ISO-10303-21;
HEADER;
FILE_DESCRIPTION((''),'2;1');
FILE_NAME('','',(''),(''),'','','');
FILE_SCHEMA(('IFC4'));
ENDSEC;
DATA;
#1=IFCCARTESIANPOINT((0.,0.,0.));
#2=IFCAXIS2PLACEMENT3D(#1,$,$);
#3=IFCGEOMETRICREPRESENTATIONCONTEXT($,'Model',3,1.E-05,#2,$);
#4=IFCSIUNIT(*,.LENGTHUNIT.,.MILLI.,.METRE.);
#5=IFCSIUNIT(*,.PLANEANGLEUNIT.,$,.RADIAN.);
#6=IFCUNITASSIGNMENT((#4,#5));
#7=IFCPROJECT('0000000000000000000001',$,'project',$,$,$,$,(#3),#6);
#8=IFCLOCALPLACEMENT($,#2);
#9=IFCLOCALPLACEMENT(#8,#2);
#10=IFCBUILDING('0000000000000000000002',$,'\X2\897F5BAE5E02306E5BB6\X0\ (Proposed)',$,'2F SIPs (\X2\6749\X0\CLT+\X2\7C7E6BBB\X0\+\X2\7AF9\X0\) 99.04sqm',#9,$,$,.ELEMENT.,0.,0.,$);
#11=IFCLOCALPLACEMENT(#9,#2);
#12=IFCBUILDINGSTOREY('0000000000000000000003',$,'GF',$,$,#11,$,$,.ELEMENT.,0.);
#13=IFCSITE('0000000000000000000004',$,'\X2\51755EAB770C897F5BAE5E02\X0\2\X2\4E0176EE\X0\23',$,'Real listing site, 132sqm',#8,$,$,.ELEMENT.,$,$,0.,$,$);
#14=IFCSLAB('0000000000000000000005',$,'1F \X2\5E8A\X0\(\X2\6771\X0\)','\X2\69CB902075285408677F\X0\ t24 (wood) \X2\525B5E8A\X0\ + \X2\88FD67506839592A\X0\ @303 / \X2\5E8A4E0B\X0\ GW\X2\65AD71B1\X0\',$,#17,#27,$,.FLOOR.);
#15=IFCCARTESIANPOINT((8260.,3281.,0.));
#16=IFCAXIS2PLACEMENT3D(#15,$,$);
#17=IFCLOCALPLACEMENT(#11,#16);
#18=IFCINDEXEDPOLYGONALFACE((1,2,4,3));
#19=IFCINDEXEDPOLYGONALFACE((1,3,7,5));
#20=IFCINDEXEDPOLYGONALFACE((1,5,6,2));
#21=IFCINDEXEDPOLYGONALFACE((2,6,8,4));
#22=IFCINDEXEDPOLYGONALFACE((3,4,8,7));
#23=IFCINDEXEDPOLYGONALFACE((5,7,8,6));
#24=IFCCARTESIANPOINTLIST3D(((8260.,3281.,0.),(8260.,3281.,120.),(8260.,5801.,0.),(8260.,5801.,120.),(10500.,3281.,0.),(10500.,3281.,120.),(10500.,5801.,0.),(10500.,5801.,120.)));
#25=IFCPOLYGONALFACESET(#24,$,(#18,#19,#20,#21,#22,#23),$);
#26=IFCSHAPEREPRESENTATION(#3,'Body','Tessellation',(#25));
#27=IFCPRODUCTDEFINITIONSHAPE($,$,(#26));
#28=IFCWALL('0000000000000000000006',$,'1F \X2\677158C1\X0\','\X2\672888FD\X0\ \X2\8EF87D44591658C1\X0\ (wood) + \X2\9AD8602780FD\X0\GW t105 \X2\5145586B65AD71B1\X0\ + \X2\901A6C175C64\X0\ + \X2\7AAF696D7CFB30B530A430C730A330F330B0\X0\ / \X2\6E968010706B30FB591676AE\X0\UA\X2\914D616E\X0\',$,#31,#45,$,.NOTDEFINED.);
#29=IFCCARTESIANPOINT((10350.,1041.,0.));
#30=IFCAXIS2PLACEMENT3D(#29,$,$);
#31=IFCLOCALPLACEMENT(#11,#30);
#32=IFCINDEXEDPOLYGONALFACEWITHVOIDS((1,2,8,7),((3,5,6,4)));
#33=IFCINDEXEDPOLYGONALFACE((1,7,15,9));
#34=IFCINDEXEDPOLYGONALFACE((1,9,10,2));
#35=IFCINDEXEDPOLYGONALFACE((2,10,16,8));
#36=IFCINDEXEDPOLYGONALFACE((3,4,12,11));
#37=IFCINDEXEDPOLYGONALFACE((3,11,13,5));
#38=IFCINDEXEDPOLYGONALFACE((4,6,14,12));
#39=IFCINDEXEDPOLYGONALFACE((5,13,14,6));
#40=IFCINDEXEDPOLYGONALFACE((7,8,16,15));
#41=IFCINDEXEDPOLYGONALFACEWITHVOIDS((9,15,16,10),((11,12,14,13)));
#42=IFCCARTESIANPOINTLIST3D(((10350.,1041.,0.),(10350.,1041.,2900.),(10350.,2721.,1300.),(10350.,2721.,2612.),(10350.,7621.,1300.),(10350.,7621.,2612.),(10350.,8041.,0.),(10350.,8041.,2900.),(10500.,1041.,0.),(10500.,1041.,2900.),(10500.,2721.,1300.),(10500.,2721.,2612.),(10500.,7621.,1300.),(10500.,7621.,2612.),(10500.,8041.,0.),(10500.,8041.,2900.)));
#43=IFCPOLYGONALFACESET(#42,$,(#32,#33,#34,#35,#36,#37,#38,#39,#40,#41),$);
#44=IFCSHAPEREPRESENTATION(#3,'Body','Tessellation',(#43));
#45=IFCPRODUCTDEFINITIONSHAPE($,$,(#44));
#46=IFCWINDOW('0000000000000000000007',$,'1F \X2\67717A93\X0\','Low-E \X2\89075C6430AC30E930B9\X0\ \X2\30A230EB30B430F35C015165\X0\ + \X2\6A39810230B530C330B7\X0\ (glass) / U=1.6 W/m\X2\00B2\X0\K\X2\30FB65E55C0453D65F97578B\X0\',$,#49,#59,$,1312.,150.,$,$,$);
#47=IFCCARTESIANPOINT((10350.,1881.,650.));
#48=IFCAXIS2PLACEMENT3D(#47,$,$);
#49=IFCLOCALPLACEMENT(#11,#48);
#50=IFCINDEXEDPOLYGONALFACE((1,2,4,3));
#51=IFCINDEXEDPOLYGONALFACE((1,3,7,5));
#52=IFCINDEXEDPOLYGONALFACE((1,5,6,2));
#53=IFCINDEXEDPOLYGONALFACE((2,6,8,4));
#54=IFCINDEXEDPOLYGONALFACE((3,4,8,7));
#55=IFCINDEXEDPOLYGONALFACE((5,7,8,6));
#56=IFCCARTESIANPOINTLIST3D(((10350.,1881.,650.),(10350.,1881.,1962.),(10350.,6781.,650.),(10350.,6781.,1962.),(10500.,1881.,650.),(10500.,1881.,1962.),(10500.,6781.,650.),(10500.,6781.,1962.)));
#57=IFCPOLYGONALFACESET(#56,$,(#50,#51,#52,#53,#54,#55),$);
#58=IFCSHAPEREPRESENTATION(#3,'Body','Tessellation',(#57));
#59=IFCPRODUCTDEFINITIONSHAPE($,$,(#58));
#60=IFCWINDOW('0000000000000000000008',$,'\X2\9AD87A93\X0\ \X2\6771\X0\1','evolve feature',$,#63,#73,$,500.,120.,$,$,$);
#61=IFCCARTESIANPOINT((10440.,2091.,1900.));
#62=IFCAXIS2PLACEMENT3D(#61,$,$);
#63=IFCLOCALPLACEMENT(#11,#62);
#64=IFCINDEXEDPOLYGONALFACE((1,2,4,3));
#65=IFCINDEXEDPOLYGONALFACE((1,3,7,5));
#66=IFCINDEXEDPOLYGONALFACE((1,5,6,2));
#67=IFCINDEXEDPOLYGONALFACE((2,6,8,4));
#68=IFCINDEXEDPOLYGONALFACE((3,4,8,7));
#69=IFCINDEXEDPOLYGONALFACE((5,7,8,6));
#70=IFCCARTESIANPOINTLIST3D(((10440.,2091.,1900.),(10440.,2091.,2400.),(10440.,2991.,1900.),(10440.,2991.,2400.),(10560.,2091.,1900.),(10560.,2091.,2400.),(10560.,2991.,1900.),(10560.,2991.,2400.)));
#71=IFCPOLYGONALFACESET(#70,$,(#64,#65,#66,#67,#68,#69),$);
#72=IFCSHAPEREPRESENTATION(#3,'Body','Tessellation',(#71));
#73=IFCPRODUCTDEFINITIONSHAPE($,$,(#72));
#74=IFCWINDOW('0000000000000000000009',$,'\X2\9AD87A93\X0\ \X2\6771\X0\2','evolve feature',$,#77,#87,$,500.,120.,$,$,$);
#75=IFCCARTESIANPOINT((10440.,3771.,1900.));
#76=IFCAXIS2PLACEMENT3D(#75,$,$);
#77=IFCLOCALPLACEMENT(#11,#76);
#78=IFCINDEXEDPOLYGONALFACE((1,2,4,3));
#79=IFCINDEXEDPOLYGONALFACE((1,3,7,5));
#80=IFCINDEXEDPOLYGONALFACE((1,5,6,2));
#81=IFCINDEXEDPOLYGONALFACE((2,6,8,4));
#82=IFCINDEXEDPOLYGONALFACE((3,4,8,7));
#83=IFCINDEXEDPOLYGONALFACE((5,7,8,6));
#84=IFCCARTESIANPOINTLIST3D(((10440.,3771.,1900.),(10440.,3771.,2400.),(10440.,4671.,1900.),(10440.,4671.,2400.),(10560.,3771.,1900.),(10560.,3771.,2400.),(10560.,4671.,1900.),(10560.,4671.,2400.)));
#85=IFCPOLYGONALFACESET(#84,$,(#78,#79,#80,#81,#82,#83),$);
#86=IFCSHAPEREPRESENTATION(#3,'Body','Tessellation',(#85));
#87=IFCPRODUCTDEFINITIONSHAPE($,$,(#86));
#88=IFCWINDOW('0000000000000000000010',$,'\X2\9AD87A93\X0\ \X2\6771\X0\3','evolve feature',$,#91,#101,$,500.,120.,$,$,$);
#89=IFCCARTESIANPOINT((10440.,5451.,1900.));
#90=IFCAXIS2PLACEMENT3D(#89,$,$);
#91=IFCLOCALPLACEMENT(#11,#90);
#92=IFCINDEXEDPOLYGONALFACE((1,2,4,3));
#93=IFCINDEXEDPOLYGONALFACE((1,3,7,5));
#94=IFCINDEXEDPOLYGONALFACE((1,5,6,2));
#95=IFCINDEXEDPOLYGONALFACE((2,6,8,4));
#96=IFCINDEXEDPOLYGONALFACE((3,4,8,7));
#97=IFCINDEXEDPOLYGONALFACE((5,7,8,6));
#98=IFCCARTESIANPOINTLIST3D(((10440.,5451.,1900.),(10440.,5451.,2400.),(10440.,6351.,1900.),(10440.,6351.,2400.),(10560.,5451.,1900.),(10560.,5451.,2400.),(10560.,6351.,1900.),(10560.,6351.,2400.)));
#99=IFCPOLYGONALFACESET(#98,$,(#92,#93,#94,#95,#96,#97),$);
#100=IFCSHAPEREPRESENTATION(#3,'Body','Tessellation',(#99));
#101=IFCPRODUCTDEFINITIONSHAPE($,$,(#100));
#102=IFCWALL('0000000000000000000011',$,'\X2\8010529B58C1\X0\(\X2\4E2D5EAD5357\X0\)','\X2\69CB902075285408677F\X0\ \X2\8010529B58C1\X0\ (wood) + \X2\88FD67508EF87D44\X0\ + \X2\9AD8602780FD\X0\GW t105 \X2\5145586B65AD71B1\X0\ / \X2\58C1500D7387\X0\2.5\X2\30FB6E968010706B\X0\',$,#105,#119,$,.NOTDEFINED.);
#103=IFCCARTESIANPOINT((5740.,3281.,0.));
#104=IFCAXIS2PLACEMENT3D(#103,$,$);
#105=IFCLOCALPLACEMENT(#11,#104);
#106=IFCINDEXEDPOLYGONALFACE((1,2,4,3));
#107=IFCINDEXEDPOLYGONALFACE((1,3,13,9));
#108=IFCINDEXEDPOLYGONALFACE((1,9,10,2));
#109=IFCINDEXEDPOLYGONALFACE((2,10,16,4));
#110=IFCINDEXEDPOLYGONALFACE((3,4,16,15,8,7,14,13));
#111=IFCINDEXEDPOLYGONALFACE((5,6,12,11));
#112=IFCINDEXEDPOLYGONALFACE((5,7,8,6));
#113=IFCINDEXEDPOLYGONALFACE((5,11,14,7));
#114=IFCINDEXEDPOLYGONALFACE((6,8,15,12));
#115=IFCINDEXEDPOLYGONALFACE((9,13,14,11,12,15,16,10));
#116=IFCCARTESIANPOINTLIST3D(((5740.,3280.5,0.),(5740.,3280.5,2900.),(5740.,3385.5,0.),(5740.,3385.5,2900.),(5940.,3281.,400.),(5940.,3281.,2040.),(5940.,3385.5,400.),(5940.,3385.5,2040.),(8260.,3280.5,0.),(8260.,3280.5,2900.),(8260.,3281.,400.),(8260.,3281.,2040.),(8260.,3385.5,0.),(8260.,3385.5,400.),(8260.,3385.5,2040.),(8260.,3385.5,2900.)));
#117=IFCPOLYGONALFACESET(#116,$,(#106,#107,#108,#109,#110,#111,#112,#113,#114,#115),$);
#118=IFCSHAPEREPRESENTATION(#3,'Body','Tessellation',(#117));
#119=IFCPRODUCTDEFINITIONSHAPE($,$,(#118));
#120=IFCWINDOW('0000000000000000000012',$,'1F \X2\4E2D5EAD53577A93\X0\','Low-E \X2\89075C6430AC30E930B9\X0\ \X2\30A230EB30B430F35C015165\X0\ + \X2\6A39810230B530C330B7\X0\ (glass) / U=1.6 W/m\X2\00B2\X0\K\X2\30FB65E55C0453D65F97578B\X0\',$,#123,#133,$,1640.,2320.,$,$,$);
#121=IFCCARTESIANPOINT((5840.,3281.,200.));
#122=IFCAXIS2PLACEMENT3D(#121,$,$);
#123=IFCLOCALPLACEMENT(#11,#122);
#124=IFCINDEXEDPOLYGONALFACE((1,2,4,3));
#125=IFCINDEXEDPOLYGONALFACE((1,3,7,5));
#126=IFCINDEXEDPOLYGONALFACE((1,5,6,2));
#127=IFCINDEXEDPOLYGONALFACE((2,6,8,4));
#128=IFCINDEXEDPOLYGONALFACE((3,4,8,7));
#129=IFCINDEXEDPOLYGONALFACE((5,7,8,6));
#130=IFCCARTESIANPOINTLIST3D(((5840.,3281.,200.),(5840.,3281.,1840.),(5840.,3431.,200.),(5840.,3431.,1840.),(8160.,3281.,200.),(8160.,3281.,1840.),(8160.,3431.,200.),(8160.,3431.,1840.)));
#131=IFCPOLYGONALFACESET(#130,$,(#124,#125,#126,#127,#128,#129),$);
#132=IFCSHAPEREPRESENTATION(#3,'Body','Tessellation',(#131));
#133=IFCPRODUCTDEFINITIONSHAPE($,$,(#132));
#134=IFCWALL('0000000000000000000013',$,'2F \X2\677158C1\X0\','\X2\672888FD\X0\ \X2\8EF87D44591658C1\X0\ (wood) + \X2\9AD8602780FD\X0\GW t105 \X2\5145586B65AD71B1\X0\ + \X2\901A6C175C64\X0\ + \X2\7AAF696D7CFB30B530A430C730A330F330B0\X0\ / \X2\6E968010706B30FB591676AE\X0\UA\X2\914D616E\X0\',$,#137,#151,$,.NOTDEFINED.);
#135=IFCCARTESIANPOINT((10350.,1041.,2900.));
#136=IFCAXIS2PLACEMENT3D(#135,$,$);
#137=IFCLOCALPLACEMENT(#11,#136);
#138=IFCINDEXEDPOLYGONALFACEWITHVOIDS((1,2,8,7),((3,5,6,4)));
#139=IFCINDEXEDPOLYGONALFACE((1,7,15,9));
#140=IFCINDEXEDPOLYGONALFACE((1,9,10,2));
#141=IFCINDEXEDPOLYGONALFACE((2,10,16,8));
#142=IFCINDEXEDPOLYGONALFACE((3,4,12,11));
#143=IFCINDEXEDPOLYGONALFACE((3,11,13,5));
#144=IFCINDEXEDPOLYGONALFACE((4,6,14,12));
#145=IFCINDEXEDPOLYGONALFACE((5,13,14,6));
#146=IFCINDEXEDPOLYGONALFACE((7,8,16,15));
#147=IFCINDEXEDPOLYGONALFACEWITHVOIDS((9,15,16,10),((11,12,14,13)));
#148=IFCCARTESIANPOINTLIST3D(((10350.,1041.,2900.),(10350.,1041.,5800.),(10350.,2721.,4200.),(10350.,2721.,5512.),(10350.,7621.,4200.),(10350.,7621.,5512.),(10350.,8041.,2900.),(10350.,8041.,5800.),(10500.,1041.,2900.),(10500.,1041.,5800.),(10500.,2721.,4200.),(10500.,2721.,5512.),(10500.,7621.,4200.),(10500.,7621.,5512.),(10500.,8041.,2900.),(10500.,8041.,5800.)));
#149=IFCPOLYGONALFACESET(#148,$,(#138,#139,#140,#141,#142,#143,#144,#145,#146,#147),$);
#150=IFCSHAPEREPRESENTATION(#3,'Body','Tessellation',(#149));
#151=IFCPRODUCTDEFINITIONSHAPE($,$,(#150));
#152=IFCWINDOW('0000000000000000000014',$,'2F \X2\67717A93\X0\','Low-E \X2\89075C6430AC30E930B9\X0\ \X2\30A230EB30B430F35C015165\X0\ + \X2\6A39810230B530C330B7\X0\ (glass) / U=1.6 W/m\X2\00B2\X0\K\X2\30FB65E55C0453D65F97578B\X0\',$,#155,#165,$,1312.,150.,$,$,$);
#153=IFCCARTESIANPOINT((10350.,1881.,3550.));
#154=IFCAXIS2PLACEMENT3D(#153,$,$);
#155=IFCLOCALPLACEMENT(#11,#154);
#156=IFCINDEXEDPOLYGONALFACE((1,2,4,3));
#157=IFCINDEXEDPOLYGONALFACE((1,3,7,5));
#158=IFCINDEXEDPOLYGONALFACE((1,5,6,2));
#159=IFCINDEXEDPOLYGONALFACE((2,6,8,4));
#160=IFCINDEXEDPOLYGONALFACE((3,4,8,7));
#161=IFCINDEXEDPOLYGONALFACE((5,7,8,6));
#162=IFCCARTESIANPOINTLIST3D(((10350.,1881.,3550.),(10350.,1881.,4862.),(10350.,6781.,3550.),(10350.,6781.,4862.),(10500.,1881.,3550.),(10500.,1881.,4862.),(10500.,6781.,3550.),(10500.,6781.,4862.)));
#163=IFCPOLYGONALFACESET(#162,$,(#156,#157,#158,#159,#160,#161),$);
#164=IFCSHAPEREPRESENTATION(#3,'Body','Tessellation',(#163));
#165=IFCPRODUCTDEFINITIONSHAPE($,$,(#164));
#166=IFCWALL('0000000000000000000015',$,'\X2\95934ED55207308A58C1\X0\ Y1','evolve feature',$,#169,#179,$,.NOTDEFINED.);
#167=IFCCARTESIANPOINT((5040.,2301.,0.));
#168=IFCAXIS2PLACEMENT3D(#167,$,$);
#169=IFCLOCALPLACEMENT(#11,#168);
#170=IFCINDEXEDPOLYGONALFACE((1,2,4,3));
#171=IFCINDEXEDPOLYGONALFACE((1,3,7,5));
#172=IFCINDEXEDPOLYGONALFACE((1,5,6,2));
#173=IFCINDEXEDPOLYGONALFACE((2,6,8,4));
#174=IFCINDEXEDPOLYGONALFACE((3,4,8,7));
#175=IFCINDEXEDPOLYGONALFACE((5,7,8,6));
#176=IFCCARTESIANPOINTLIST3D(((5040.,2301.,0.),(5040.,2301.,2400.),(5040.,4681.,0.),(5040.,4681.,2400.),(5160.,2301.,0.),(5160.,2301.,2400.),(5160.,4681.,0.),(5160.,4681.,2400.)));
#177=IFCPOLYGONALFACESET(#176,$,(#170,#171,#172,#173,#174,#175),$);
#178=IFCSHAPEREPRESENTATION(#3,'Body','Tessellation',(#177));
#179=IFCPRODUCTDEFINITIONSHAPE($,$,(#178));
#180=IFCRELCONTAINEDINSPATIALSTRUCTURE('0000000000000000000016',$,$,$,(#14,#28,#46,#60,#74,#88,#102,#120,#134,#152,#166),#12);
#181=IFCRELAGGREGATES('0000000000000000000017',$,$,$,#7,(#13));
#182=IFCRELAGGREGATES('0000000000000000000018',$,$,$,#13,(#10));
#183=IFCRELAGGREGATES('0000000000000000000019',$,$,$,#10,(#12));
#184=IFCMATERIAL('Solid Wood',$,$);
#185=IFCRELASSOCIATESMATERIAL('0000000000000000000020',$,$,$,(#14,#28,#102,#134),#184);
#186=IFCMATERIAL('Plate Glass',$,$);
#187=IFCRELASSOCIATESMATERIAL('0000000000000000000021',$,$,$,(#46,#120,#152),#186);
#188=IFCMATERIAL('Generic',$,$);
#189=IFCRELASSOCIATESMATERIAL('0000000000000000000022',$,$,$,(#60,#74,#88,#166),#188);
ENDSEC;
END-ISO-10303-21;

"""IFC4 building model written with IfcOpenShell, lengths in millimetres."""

from ifc_helpers import new_model, si_unit, frame, frame_2d, origin, place, context, project, spatial, rectangle, extrude, material, element, fill, save


model = new_model("IFC4")

# Units and contexts
model_context = context("Model", 3, precision=1e-05, world=origin())
ifc_project = project(units=[si_unit("LENGTHUNIT", "METRE", prefix="MILLI"), si_unit("PLANEANGLEUNIT", "RADIAN")], contexts=[model_context])

# Site, building, storey
site_placement = place(None, origin())
site = spatial("IfcSite", under=ifc_project, at=site_placement, Name="兵庫県西宮市2丁目23", ObjectType="Real listing site, 132sqm", CompositionType="ELEMENT", RefElevation=0.0)
building_placement = place(site_placement, origin())
building = spatial("IfcBuilding", under=site, at=building_placement, Name="西宮市の家 (Proposed)", ObjectType="2F SIPs (杉CLT+籾殻+竹) 99.04sqm", CompositionType="ELEMENT", ElevationOfRefHeight=0.0, ElevationOfTerrain=0.0)
storey_placement = place(building_placement, origin())
storey = spatial("IfcBuildingStorey", under=building, at=storey_placement, Name="GF", CompositionType="ELEMENT", Elevation=0.0)

# Slab
ifc_material_1 = material(Name="Solid Wood")
slab_placement = place(storey_placement, frame((8260.0, 3281.0, 0.0)))
element("IfcSlab", 1, at=slab_placement, inside=storey, material=ifc_material_1, Name="1F 床(東)", Description="構造用合板 t24 (wood) 剛床 + 製材根太 @303 / 床下 GW断熱", PredefinedType="FLOOR", context=model_context, shape_type="SweptSolid", body=[
    extrude(rectangle(XDim=2240.0, YDim=2520.0, at=frame_2d((1120.0, 1260.0))), frame((8260.0, 3281.0, 0.0)), (0.0, 0.0, 1.0), 120.0),
])

# Wall, openings, windows
wall_1_placement = place(storey_placement, frame((10350.0, 1041.0, 0.0)))
wall_1 = element("IfcWall", 2, at=wall_1_placement, inside=storey, material=ifc_material_1, Name="1F 東壁", Description="木製 軸組外壁 (wood) + 高性能GW t105 充填断熱 + 通気層 + 窯業系サイディング / 準耐火・外皮UA配慮", PredefinedType="NOTDEFINED", context=model_context, shape_type="SweptSolid", body=[
    extrude(rectangle(XDim=150.0, YDim=7000.0, at=frame_2d((75.0, 3500.0))), frame((10350.0, 1041.0, 0.0)), (0.0, 0.0, 1.0), 2900.0),
])
opening_1_placement = place(storey_placement, frame((10350.0, 1881.0, 650.0)))
opening_1 = element("IfcOpeningElement", 3, at=opening_1_placement, cuts=wall_1, PredefinedType="NOTDEFINED", context=model_context, shape_type="SweptSolid", body=[
    extrude(rectangle(XDim=150.0, YDim=4900.0, at=frame_2d((75.0, 2450.0))), frame((10350.0, 1881.0, 650.0)), (0.0, 0.0, 1.0), 1312.0),
])
opening_2_placement = place(storey_placement, frame((10440.0, 2091.0, 1900.0)))
opening_2 = element("IfcOpeningElement", 4, at=opening_2_placement, cuts=wall_1, PredefinedType="NOTDEFINED", context=model_context, shape_type="SweptSolid", body=[
    extrude(rectangle(XDim=120.0, YDim=900.0, at=frame_2d((60.0, 450.0))), frame((10440.0, 2091.0, 1900.0)), (0.0, 0.0, 1.0), 500.0),
])
opening_3_placement = place(storey_placement, frame((10440.0, 3771.0, 1900.0)))
opening_3 = element("IfcOpeningElement", 5, at=opening_3_placement, cuts=wall_1, PredefinedType="NOTDEFINED", context=model_context, shape_type="SweptSolid", body=[
    extrude(rectangle(XDim=120.0, YDim=900.0, at=frame_2d((60.0, 450.0))), frame((10440.0, 3771.0, 1900.0)), (0.0, 0.0, 1.0), 500.0),
])
opening_4_placement = place(storey_placement, frame((10440.0, 5451.0, 1900.0)))
opening_4 = element("IfcOpeningElement", 6, at=opening_4_placement, cuts=wall_1, PredefinedType="NOTDEFINED", context=model_context, shape_type="SweptSolid", body=[
    extrude(rectangle(XDim=120.0, YDim=900.0, at=frame_2d((60.0, 450.0))), frame((10440.0, 5451.0, 1900.0)), (0.0, 0.0, 1.0), 500.0),
])
ifc_material_2 = material(Name="Plate Glass")
window_1_placement = place(storey_placement, frame((10350.0, 1881.0, 650.0)))
window_1 = element("IfcWindow", 7, at=window_1_placement, inside=storey, material=ifc_material_2, Name="1F 東窓", Description="Low-E 複層ガラス アルゴン封入 + 樹脂サッシ (glass) / U=1.6 W/m²K・日射取得型", OverallHeight=1312.0, OverallWidth=150.0, context=model_context, shape_type="SweptSolid", body=[
    extrude(rectangle(XDim=150.0, YDim=4900.0, at=frame_2d((75.0, 2450.0))), frame((10350.0, 1881.0, 650.0)), (0.0, 0.0, 1.0), 1312.0),
])
fill(opening_1, window_1)
ifc_material_3 = material(Name="Generic")
window_2_placement = place(storey_placement, frame((10440.0, 2091.0, 1900.0)))
window_2 = element("IfcWindow", 8, at=window_2_placement, inside=storey, material=ifc_material_3, Name="高窓 東1", Description="evolve feature", OverallHeight=500.0, OverallWidth=120.0, context=model_context, shape_type="SweptSolid", body=[
    extrude(rectangle(XDim=120.0, YDim=900.0, at=frame_2d((60.0, 450.0))), frame((10440.0, 2091.0, 1900.0)), (0.0, 0.0, 1.0), 500.0),
])
fill(opening_2, window_2)
window_3_placement = place(storey_placement, frame((10440.0, 3771.0, 1900.0)))
window_3 = element("IfcWindow", 9, at=window_3_placement, inside=storey, material=ifc_material_3, Name="高窓 東2", Description="evolve feature", OverallHeight=500.0, OverallWidth=120.0, context=model_context, shape_type="SweptSolid", body=[
    extrude(rectangle(XDim=120.0, YDim=900.0, at=frame_2d((60.0, 450.0))), frame((10440.0, 3771.0, 1900.0)), (0.0, 0.0, 1.0), 500.0),
])
fill(opening_3, window_3)
window_4_placement = place(storey_placement, frame((10440.0, 5451.0, 1900.0)))
window_4 = element("IfcWindow", 10, at=window_4_placement, inside=storey, material=ifc_material_3, Name="高窓 東3", Description="evolve feature", OverallHeight=500.0, OverallWidth=120.0, context=model_context, shape_type="SweptSolid", body=[
    extrude(rectangle(XDim=120.0, YDim=900.0, at=frame_2d((60.0, 450.0))), frame((10440.0, 5451.0, 1900.0)), (0.0, 0.0, 1.0), 500.0),
])
fill(opening_4, window_4)

# Wall, opening, window
wall_2_placement = place(storey_placement, frame((5740.0, 3281.0, 0.0)))
wall_2 = element("IfcWall", 11, at=wall_2_placement, inside=storey, material=ifc_material_1, Name="耐力壁(中庭南)", Description="構造用合板 耐力壁 (wood) + 製材軸組 + 高性能GW t105 充填断熱 / 壁倍率2.5・準耐火", PredefinedType="NOTDEFINED", context=model_context, shape_type="SweptSolid", body=[
    extrude(rectangle(XDim=2520.0, YDim=105.0, at=frame_2d((1260.0, 52.0))), frame((5740.0, 3281.0, 0.0)), (0.0, 0.0, 1.0), 2900.0),
])
opening_5_placement = place(storey_placement, frame((5840.0, 3281.0, 200.0)))
opening_5 = element("IfcOpeningElement", 12, at=opening_5_placement, cuts=wall_2, PredefinedType="NOTDEFINED", context=model_context, shape_type="SweptSolid", body=[
    extrude(rectangle(XDim=2320.0, YDim=150.0, at=frame_2d((1160.0, 75.0))), frame((5840.0, 3281.0, 200.0)), (0.0, 0.0, 1.0), 1640.0),
])
window_5_placement = place(storey_placement, frame((5840.0, 3281.0, 200.0)))
window_5 = element("IfcWindow", 13, at=window_5_placement, inside=storey, material=ifc_material_2, Name="1F 中庭南窓", Description="Low-E 複層ガラス アルゴン封入 + 樹脂サッシ (glass) / U=1.6 W/m²K・日射取得型", OverallHeight=1640.0, OverallWidth=2320.0, context=model_context, shape_type="SweptSolid", body=[
    extrude(rectangle(XDim=2320.0, YDim=150.0, at=frame_2d((1160.0, 75.0))), frame((5840.0, 3281.0, 200.0)), (0.0, 0.0, 1.0), 1640.0),
])
fill(opening_5, window_5)

# Wall, opening, window
wall_3_placement = place(storey_placement, frame((10350.0, 1041.0, 2900.0)))
wall_3 = element("IfcWall", 14, at=wall_3_placement, inside=storey, material=ifc_material_1, Name="2F 東壁", Description="木製 軸組外壁 (wood) + 高性能GW t105 充填断熱 + 通気層 + 窯業系サイディング / 準耐火・外皮UA配慮", PredefinedType="NOTDEFINED", context=model_context, shape_type="SweptSolid", body=[
    extrude(rectangle(XDim=150.0, YDim=7000.0, at=frame_2d((75.0, 3500.0))), frame((10350.0, 1041.0, 2900.0)), (0.0, 0.0, 1.0), 2900.0),
])
opening_6_placement = place(storey_placement, frame((10350.0, 1881.0, 3550.0)))
opening_6 = element("IfcOpeningElement", 15, at=opening_6_placement, cuts=wall_3, PredefinedType="NOTDEFINED", context=model_context, shape_type="SweptSolid", body=[
    extrude(rectangle(XDim=150.0, YDim=4900.0, at=frame_2d((75.0, 2450.0))), frame((10350.0, 1881.0, 3550.0)), (0.0, 0.0, 1.0), 1312.0),
])
window_6_placement = place(storey_placement, frame((10350.0, 1881.0, 3550.0)))
window_6 = element("IfcWindow", 16, at=window_6_placement, inside=storey, material=ifc_material_2, Name="2F 東窓", Description="Low-E 複層ガラス アルゴン封入 + 樹脂サッシ (glass) / U=1.6 W/m²K・日射取得型", OverallHeight=1312.0, OverallWidth=150.0, context=model_context, shape_type="SweptSolid", body=[
    extrude(rectangle(XDim=150.0, YDim=4900.0, at=frame_2d((75.0, 2450.0))), frame((10350.0, 1881.0, 3550.0)), (0.0, 0.0, 1.0), 1312.0),
])
fill(opening_6, window_6)

# Wall
wall_4_placement = place(storey_placement, frame((5040.0, 2301.0, 0.0)))
element("IfcWall", 17, at=wall_4_placement, inside=storey, material=ifc_material_3, Name="間仕切り壁 Y1", Description="evolve feature", PredefinedType="NOTDEFINED", context=model_context, shape_type="SweptSolid", body=[
    extrude(rectangle(XDim=120.0, YDim=2380.0, at=frame_2d((60.0, 1190.0))), frame((5040.0, 2301.0, 0.0)), (0.0, 0.0, 1.0), 2400.0),
])

save(model, "model.ifc")
